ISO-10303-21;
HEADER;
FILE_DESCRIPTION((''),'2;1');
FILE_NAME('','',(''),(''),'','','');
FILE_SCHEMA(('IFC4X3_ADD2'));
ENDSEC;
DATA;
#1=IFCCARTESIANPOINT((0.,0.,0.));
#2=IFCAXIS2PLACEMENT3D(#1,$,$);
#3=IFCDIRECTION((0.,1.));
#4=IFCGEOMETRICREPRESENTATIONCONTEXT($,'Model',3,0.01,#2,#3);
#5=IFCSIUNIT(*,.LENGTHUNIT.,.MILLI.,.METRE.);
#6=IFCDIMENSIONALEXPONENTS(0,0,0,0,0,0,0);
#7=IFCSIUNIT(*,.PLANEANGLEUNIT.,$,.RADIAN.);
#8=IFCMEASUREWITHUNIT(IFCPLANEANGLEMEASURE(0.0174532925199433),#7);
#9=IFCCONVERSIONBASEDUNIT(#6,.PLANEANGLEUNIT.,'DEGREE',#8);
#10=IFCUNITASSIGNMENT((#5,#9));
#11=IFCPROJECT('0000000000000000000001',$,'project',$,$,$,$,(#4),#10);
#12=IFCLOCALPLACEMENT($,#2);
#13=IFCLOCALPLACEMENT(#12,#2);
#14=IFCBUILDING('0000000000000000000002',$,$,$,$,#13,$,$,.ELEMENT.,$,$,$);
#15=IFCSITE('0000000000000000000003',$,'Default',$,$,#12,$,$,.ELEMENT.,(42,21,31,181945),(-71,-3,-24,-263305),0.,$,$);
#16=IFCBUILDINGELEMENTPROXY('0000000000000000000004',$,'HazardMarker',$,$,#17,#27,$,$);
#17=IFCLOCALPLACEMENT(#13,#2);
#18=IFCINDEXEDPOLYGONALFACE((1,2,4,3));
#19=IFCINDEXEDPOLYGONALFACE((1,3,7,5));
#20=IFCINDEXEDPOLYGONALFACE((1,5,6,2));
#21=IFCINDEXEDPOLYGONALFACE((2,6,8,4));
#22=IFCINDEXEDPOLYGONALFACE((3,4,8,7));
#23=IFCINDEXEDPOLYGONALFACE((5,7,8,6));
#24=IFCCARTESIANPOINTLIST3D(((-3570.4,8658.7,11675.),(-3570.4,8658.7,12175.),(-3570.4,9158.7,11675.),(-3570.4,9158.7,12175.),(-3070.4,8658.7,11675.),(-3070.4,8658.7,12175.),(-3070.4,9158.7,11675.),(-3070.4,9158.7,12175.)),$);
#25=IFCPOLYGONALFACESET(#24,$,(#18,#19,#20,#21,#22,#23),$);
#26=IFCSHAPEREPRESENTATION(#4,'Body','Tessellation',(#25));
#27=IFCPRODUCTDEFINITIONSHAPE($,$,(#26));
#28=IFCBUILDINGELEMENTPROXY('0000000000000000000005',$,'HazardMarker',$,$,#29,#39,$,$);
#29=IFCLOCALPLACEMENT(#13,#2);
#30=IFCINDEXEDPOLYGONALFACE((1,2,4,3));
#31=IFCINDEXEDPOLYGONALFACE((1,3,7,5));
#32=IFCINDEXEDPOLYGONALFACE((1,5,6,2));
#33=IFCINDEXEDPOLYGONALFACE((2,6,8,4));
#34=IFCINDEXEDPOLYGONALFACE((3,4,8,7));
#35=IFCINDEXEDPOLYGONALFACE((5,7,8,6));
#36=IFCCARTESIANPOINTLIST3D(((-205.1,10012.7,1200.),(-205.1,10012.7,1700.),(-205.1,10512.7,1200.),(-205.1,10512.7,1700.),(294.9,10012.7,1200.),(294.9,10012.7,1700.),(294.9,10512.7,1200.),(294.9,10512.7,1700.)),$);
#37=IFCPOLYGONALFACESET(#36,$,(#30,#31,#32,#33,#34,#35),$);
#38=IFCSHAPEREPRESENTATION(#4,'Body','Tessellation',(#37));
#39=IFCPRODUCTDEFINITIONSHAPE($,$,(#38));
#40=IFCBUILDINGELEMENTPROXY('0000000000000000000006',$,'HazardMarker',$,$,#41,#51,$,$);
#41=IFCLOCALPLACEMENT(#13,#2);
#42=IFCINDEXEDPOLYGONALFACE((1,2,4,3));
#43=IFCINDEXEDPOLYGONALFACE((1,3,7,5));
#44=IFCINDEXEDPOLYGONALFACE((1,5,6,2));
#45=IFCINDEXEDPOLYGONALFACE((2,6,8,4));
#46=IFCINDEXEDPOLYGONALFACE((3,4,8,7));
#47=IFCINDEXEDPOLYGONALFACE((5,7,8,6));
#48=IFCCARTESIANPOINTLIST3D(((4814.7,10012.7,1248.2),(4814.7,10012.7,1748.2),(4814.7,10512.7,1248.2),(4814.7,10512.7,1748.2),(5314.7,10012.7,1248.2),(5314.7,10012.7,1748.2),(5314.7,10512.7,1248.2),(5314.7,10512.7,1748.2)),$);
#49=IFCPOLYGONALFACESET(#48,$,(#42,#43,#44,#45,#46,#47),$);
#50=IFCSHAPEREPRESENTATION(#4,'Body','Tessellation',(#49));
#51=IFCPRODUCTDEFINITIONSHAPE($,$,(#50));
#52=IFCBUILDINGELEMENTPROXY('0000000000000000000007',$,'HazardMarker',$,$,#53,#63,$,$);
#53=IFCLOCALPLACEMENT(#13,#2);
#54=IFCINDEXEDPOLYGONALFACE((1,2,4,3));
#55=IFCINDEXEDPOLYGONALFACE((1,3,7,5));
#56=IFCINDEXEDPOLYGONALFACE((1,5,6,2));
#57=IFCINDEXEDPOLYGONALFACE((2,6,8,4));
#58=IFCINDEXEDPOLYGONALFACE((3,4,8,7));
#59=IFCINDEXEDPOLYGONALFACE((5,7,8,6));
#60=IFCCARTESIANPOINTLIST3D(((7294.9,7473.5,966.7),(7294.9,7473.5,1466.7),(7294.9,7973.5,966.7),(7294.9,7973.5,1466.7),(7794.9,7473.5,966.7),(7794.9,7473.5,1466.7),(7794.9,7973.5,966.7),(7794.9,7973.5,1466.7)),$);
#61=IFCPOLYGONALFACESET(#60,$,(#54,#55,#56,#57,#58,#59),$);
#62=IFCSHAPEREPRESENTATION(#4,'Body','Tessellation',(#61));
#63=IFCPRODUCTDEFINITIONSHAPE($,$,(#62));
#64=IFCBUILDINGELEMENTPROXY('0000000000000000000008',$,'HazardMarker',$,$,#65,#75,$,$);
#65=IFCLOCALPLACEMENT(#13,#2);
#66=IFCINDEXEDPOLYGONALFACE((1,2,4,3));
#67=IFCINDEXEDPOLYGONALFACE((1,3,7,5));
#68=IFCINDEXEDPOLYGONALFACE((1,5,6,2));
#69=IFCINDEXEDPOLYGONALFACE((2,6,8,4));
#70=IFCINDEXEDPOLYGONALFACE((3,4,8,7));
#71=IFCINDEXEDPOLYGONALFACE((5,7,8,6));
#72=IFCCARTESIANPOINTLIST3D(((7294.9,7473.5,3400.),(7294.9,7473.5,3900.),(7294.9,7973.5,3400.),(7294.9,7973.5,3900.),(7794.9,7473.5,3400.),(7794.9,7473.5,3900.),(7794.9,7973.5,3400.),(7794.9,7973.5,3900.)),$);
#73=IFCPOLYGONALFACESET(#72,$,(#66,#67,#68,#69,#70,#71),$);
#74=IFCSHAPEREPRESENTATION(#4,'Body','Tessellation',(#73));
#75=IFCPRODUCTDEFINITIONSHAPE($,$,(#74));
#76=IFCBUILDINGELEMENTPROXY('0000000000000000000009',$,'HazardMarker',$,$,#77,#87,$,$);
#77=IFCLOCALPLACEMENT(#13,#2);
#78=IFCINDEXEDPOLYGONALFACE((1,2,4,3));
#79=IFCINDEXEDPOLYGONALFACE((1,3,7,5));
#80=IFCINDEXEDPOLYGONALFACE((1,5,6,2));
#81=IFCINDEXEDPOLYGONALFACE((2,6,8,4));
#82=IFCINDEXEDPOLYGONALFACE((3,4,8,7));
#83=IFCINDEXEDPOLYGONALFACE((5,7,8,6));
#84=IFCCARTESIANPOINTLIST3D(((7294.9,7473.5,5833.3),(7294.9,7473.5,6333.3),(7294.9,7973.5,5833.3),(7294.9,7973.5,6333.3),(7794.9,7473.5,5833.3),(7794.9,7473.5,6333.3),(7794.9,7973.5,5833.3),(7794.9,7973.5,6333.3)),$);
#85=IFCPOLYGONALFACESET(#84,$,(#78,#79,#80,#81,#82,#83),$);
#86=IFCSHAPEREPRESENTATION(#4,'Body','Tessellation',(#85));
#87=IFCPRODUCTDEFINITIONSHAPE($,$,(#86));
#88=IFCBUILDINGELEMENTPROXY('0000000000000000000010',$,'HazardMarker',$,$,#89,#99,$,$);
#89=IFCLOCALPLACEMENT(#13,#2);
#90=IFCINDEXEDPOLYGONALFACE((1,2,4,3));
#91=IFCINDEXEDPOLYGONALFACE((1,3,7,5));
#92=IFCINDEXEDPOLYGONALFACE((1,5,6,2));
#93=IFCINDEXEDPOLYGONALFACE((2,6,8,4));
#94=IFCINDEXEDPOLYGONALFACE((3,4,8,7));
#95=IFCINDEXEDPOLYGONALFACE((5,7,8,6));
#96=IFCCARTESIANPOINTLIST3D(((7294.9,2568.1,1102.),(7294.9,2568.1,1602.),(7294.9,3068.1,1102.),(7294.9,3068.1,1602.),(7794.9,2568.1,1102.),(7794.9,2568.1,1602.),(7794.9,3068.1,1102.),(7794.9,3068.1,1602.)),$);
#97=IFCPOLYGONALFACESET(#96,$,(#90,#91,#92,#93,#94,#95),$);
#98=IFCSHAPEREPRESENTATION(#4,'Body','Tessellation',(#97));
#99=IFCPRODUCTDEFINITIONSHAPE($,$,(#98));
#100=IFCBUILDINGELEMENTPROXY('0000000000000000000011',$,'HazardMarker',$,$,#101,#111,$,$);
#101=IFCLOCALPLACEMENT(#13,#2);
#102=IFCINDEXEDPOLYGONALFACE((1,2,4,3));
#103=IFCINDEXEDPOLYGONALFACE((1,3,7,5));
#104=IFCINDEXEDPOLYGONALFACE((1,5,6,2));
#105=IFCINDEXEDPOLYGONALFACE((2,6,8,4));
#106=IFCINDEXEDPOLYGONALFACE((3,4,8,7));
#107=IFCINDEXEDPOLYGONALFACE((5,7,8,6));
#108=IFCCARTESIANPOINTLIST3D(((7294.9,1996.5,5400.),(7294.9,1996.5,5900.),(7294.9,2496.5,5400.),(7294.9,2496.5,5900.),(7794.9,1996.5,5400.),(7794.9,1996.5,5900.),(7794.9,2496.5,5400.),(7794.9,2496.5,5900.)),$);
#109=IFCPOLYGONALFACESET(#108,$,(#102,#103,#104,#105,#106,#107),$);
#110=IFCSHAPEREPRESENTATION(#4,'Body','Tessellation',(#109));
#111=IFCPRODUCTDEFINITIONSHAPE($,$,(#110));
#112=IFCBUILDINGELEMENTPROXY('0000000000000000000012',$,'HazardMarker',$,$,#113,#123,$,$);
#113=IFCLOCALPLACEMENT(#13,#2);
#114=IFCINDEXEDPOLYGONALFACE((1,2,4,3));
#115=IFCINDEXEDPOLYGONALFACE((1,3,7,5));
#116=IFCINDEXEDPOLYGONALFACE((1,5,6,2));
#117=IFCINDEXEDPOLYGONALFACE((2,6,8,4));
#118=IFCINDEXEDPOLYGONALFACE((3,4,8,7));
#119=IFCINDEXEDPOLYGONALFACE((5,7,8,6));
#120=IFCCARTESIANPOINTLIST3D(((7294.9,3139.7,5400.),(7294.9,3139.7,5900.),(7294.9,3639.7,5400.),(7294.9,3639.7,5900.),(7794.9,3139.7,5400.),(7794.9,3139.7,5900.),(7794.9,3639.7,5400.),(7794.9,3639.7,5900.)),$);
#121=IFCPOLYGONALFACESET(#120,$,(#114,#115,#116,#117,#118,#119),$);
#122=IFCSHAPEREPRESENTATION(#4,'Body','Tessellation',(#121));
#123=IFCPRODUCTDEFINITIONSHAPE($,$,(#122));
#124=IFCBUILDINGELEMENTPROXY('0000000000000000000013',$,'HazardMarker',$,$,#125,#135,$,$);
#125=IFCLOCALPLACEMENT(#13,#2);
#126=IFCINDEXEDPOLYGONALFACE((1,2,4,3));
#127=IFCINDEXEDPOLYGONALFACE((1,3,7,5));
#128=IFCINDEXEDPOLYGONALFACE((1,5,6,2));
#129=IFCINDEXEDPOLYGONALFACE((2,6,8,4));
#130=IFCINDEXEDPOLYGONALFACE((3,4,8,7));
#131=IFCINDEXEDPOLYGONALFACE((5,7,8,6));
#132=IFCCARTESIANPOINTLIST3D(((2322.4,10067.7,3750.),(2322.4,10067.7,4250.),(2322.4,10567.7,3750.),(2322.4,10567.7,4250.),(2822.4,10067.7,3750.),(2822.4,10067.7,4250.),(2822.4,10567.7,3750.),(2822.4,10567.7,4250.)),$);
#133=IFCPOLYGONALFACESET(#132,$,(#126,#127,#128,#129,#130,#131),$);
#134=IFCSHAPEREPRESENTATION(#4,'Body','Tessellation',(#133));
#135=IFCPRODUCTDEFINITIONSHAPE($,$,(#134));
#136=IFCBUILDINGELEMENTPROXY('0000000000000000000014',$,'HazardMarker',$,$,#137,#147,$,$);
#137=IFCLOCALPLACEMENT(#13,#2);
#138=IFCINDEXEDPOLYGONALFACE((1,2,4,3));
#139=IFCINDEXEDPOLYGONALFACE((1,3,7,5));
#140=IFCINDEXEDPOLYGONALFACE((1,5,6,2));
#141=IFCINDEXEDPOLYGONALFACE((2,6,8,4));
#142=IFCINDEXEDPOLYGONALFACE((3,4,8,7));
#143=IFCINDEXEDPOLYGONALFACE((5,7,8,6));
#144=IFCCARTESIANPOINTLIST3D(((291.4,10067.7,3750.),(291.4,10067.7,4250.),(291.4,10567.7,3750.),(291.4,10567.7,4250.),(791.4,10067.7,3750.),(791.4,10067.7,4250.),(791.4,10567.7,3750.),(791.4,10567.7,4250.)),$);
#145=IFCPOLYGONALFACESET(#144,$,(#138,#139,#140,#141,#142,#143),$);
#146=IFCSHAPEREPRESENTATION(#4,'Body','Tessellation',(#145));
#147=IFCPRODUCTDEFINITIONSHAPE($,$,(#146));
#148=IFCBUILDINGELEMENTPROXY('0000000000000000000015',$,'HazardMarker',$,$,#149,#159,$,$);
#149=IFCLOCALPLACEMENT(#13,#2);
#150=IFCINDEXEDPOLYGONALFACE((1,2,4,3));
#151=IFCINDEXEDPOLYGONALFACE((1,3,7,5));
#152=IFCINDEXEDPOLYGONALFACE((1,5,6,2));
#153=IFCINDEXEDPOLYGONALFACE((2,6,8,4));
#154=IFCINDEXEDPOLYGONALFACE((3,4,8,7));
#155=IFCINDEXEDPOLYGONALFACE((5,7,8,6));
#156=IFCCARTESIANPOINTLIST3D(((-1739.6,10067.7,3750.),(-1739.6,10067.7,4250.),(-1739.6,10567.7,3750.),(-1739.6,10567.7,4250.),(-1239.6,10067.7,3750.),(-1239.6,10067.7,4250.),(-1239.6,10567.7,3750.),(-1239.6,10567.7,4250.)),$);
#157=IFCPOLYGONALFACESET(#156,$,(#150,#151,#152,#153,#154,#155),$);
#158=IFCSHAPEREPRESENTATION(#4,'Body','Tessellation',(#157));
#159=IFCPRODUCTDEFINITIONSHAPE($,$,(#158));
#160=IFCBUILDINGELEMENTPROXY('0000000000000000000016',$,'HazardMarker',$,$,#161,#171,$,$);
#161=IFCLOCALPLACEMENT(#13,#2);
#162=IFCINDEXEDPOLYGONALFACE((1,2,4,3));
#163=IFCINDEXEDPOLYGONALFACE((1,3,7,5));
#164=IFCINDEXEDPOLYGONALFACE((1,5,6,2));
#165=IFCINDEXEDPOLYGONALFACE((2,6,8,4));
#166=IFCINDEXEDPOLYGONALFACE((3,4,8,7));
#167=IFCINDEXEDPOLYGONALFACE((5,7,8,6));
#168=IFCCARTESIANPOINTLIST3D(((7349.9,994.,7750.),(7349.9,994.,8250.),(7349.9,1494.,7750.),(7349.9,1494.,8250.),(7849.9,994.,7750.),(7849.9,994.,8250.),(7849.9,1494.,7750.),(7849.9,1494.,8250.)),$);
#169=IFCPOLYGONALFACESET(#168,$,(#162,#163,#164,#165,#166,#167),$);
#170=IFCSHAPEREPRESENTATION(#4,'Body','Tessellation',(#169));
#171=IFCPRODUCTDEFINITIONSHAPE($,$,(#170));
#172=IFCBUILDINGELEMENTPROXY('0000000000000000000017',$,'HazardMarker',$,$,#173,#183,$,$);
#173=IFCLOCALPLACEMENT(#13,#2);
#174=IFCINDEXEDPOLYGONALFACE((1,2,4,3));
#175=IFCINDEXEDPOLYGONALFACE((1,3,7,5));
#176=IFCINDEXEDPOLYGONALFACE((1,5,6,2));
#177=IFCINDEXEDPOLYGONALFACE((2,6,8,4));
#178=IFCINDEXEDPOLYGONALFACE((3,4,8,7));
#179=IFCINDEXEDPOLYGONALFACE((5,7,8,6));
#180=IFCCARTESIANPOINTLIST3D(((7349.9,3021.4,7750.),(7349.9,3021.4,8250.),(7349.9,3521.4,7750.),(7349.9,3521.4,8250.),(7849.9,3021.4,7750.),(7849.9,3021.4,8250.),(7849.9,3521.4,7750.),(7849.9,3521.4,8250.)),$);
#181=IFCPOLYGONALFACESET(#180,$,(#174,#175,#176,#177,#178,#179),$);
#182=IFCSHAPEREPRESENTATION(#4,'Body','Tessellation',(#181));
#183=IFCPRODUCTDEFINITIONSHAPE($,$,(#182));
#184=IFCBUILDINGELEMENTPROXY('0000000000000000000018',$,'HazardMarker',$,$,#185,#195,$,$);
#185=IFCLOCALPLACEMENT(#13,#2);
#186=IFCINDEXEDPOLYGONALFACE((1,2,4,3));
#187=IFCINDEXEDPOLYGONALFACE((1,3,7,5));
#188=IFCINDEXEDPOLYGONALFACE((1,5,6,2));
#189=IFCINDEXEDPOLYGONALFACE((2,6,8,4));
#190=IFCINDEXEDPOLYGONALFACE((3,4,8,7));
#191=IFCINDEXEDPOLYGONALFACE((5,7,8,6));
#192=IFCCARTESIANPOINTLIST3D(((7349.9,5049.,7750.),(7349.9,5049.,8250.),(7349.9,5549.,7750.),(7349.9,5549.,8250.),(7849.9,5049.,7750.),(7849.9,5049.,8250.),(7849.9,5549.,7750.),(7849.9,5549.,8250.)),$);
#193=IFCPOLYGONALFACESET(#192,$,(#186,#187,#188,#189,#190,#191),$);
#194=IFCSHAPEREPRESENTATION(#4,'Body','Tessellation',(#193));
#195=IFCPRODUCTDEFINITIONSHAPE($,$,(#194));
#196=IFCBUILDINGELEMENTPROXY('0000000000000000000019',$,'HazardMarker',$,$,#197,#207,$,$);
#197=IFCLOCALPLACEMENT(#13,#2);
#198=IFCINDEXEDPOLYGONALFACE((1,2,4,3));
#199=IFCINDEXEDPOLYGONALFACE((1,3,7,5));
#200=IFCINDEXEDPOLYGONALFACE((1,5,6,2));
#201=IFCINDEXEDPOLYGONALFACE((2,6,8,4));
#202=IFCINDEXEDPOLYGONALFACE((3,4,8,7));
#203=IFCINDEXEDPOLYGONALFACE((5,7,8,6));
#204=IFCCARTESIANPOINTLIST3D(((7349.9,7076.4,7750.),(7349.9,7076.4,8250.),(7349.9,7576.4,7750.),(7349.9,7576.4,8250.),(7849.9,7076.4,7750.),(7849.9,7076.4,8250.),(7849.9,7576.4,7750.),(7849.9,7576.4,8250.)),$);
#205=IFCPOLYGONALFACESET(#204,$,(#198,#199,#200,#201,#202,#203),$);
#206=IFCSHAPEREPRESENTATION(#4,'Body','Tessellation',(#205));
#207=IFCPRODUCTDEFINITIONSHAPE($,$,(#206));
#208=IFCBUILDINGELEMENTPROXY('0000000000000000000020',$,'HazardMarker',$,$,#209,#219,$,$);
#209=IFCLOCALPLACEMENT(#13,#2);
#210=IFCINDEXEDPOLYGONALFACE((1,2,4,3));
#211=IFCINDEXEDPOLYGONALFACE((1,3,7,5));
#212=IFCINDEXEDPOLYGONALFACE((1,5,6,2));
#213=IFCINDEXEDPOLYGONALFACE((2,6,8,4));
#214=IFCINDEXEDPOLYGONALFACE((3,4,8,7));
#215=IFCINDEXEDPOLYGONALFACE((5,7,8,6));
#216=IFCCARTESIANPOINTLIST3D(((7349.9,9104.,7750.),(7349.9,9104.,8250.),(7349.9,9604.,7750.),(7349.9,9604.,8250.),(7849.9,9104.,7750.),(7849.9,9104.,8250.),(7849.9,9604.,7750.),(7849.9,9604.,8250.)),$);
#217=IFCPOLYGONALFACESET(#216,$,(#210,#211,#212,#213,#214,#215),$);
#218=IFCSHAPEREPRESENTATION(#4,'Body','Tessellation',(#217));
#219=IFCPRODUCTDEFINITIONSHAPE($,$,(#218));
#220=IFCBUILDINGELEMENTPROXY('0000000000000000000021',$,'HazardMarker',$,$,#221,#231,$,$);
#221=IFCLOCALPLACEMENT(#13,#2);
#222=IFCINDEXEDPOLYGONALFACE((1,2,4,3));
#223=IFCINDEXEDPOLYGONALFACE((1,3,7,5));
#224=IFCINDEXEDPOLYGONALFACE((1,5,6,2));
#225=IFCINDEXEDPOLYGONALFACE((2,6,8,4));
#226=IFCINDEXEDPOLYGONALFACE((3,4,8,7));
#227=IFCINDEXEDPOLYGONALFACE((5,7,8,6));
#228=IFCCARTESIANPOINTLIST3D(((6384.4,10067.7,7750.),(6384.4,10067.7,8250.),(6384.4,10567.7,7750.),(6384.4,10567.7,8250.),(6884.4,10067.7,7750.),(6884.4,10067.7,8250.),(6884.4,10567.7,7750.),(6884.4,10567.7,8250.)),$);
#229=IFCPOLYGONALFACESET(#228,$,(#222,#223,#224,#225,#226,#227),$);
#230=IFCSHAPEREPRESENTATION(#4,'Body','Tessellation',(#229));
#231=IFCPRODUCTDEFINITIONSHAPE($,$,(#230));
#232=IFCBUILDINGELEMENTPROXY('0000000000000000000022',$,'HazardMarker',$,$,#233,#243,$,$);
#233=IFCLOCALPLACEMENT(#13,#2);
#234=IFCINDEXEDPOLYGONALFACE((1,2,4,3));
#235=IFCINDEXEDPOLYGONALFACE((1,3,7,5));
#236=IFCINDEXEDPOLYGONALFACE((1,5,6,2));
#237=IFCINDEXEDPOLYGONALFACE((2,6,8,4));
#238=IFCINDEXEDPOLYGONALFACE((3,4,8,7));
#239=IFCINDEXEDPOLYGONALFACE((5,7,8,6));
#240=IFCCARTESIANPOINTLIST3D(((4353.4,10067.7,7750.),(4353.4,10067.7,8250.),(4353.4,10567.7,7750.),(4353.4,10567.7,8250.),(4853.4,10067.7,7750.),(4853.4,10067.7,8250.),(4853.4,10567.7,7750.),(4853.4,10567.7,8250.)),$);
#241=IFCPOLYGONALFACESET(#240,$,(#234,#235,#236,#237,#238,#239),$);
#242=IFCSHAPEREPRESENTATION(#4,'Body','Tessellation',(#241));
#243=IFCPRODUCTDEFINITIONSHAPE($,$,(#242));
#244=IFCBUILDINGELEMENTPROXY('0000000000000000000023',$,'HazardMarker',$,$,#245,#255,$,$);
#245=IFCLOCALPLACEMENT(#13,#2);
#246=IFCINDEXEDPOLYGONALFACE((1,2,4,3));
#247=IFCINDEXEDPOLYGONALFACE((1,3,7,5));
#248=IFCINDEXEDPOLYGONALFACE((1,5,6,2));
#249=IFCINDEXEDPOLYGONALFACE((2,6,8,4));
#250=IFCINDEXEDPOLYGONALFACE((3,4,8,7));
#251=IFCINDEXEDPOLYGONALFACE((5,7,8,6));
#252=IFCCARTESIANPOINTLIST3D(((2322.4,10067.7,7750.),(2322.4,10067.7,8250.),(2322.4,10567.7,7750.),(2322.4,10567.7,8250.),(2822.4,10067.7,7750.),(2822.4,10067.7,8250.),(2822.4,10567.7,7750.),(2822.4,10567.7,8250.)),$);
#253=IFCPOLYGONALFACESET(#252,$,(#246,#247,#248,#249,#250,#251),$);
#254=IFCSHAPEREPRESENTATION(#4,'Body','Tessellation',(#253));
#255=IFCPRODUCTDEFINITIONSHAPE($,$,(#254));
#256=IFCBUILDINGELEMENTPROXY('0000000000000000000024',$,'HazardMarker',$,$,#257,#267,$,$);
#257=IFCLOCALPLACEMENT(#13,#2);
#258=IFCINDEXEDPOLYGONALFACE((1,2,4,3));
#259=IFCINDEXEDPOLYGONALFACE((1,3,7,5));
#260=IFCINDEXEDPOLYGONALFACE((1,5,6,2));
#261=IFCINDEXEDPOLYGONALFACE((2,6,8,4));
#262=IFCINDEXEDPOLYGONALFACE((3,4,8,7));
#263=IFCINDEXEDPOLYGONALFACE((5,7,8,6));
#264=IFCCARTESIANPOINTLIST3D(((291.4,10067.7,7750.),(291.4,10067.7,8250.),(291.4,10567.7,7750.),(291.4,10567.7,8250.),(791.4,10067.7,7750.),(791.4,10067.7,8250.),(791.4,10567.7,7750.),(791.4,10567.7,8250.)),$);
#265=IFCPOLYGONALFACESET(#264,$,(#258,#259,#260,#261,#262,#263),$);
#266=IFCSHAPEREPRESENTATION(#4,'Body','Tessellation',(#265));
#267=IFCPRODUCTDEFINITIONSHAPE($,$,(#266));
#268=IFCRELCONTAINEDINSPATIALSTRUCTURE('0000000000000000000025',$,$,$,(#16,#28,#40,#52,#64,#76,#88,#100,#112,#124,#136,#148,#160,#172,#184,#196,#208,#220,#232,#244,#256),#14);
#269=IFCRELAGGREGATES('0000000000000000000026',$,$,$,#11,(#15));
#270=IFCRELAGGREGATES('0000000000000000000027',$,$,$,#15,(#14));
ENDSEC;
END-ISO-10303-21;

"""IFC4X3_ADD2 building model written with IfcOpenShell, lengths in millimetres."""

from ifc_helpers import new_model, entity, si_unit, converted_unit, direction, frame, origin, place, context, project, spatial, rectangle, extrude, element, save


model = new_model("IFC4X3_ADD2")

# Units and contexts
model_context = context("Model", 3, precision=0.01, world=origin(), true_north=direction((0.0, 1.0)))
ifc_project = project(units=[si_unit("LENGTHUNIT", "METRE", prefix="MILLI"), converted_unit("PLANEANGLEUNIT", "DEGREE", entity("IfcPlaneAngleMeasure", 0.0174532925199433), si_unit("PLANEANGLEUNIT", "RADIAN"), dimensions=[0, 0, 0, 0, 0, 0, 0])], contexts=[model_context])

# Site, building
site_placement = place(None, origin())
site = spatial("IfcSite", under=ifc_project, at=site_placement, Name="Default", CompositionType="ELEMENT", RefLatitude=(42, 21, 31, 181945), RefLongitude=(-71, -3, -24, -263305), RefElevation=0.0)
building_placement = place(site_placement, origin())
building = spatial("IfcBuilding", under=site, at=building_placement, CompositionType="ELEMENT")

# Building element proxies
for number, where, name in (
    (1, (-3320.4, 8908.7, 11925.0), "HazardMarker"),
    (2, (44.9, 10262.7, 1450.0), "HazardMarker"),
    (3, (5064.7, 10262.7, 1498.2), "HazardMarker"),
    (4, (7544.9, 7723.5, 1216.7), "HazardMarker"),
    (5, (7544.9, 7723.5, 3650.0), "HazardMarker"),
    (6, (7544.9, 7723.5, 6083.3), "HazardMarker"),
    (7, (7544.9, 2818.1, 1352.0), "HazardMarker"),
    (8, (7544.9, 2246.5, 5650.0), "HazardMarker"),
    (9, (7544.9, 3389.7, 5650.0), "HazardMarker"),
    (10, (2572.4, 10317.7, 4000.0), "HazardMarker"),
    (11, (541.4, 10317.7, 4000.0), "HazardMarker"),
    (12, (-1489.6, 10317.7, 4000.0), "HazardMarker"),
    (13, (7599.9, 1244.0, 8000.0), "HazardMarker"),
    (14, (7599.9, 3271.4, 8000.0), "HazardMarker"),
    (15, (7599.9, 5298.9, 8000.0), "HazardMarker"),
    (16, (7599.9, 7326.4, 8000.0), "HazardMarker"),
    (17, (7599.9, 9354.0, 8000.0), "HazardMarker"),
    (18, (6634.4, 10317.7, 8000.0), "HazardMarker"),
    (19, (4603.4, 10317.7, 8000.0), "HazardMarker"),
    (20, (2572.4, 10317.7, 8000.0), "HazardMarker"),
    (21, (541.4, 10317.7, 8000.0), "HazardMarker"),
):
    element("IfcBuildingElementProxy", number, at=place(None, frame(where)), inside=building, Name=name, context=model_context, shape_type="SweptSolid", body=[
        extrude(rectangle(XDim=500.0, YDim=500.0), frame((0.0, 0.0, -250.0)), (0.0, 0.0, 1.0), 500.0),
    ])

save(model, "model.ifc")
